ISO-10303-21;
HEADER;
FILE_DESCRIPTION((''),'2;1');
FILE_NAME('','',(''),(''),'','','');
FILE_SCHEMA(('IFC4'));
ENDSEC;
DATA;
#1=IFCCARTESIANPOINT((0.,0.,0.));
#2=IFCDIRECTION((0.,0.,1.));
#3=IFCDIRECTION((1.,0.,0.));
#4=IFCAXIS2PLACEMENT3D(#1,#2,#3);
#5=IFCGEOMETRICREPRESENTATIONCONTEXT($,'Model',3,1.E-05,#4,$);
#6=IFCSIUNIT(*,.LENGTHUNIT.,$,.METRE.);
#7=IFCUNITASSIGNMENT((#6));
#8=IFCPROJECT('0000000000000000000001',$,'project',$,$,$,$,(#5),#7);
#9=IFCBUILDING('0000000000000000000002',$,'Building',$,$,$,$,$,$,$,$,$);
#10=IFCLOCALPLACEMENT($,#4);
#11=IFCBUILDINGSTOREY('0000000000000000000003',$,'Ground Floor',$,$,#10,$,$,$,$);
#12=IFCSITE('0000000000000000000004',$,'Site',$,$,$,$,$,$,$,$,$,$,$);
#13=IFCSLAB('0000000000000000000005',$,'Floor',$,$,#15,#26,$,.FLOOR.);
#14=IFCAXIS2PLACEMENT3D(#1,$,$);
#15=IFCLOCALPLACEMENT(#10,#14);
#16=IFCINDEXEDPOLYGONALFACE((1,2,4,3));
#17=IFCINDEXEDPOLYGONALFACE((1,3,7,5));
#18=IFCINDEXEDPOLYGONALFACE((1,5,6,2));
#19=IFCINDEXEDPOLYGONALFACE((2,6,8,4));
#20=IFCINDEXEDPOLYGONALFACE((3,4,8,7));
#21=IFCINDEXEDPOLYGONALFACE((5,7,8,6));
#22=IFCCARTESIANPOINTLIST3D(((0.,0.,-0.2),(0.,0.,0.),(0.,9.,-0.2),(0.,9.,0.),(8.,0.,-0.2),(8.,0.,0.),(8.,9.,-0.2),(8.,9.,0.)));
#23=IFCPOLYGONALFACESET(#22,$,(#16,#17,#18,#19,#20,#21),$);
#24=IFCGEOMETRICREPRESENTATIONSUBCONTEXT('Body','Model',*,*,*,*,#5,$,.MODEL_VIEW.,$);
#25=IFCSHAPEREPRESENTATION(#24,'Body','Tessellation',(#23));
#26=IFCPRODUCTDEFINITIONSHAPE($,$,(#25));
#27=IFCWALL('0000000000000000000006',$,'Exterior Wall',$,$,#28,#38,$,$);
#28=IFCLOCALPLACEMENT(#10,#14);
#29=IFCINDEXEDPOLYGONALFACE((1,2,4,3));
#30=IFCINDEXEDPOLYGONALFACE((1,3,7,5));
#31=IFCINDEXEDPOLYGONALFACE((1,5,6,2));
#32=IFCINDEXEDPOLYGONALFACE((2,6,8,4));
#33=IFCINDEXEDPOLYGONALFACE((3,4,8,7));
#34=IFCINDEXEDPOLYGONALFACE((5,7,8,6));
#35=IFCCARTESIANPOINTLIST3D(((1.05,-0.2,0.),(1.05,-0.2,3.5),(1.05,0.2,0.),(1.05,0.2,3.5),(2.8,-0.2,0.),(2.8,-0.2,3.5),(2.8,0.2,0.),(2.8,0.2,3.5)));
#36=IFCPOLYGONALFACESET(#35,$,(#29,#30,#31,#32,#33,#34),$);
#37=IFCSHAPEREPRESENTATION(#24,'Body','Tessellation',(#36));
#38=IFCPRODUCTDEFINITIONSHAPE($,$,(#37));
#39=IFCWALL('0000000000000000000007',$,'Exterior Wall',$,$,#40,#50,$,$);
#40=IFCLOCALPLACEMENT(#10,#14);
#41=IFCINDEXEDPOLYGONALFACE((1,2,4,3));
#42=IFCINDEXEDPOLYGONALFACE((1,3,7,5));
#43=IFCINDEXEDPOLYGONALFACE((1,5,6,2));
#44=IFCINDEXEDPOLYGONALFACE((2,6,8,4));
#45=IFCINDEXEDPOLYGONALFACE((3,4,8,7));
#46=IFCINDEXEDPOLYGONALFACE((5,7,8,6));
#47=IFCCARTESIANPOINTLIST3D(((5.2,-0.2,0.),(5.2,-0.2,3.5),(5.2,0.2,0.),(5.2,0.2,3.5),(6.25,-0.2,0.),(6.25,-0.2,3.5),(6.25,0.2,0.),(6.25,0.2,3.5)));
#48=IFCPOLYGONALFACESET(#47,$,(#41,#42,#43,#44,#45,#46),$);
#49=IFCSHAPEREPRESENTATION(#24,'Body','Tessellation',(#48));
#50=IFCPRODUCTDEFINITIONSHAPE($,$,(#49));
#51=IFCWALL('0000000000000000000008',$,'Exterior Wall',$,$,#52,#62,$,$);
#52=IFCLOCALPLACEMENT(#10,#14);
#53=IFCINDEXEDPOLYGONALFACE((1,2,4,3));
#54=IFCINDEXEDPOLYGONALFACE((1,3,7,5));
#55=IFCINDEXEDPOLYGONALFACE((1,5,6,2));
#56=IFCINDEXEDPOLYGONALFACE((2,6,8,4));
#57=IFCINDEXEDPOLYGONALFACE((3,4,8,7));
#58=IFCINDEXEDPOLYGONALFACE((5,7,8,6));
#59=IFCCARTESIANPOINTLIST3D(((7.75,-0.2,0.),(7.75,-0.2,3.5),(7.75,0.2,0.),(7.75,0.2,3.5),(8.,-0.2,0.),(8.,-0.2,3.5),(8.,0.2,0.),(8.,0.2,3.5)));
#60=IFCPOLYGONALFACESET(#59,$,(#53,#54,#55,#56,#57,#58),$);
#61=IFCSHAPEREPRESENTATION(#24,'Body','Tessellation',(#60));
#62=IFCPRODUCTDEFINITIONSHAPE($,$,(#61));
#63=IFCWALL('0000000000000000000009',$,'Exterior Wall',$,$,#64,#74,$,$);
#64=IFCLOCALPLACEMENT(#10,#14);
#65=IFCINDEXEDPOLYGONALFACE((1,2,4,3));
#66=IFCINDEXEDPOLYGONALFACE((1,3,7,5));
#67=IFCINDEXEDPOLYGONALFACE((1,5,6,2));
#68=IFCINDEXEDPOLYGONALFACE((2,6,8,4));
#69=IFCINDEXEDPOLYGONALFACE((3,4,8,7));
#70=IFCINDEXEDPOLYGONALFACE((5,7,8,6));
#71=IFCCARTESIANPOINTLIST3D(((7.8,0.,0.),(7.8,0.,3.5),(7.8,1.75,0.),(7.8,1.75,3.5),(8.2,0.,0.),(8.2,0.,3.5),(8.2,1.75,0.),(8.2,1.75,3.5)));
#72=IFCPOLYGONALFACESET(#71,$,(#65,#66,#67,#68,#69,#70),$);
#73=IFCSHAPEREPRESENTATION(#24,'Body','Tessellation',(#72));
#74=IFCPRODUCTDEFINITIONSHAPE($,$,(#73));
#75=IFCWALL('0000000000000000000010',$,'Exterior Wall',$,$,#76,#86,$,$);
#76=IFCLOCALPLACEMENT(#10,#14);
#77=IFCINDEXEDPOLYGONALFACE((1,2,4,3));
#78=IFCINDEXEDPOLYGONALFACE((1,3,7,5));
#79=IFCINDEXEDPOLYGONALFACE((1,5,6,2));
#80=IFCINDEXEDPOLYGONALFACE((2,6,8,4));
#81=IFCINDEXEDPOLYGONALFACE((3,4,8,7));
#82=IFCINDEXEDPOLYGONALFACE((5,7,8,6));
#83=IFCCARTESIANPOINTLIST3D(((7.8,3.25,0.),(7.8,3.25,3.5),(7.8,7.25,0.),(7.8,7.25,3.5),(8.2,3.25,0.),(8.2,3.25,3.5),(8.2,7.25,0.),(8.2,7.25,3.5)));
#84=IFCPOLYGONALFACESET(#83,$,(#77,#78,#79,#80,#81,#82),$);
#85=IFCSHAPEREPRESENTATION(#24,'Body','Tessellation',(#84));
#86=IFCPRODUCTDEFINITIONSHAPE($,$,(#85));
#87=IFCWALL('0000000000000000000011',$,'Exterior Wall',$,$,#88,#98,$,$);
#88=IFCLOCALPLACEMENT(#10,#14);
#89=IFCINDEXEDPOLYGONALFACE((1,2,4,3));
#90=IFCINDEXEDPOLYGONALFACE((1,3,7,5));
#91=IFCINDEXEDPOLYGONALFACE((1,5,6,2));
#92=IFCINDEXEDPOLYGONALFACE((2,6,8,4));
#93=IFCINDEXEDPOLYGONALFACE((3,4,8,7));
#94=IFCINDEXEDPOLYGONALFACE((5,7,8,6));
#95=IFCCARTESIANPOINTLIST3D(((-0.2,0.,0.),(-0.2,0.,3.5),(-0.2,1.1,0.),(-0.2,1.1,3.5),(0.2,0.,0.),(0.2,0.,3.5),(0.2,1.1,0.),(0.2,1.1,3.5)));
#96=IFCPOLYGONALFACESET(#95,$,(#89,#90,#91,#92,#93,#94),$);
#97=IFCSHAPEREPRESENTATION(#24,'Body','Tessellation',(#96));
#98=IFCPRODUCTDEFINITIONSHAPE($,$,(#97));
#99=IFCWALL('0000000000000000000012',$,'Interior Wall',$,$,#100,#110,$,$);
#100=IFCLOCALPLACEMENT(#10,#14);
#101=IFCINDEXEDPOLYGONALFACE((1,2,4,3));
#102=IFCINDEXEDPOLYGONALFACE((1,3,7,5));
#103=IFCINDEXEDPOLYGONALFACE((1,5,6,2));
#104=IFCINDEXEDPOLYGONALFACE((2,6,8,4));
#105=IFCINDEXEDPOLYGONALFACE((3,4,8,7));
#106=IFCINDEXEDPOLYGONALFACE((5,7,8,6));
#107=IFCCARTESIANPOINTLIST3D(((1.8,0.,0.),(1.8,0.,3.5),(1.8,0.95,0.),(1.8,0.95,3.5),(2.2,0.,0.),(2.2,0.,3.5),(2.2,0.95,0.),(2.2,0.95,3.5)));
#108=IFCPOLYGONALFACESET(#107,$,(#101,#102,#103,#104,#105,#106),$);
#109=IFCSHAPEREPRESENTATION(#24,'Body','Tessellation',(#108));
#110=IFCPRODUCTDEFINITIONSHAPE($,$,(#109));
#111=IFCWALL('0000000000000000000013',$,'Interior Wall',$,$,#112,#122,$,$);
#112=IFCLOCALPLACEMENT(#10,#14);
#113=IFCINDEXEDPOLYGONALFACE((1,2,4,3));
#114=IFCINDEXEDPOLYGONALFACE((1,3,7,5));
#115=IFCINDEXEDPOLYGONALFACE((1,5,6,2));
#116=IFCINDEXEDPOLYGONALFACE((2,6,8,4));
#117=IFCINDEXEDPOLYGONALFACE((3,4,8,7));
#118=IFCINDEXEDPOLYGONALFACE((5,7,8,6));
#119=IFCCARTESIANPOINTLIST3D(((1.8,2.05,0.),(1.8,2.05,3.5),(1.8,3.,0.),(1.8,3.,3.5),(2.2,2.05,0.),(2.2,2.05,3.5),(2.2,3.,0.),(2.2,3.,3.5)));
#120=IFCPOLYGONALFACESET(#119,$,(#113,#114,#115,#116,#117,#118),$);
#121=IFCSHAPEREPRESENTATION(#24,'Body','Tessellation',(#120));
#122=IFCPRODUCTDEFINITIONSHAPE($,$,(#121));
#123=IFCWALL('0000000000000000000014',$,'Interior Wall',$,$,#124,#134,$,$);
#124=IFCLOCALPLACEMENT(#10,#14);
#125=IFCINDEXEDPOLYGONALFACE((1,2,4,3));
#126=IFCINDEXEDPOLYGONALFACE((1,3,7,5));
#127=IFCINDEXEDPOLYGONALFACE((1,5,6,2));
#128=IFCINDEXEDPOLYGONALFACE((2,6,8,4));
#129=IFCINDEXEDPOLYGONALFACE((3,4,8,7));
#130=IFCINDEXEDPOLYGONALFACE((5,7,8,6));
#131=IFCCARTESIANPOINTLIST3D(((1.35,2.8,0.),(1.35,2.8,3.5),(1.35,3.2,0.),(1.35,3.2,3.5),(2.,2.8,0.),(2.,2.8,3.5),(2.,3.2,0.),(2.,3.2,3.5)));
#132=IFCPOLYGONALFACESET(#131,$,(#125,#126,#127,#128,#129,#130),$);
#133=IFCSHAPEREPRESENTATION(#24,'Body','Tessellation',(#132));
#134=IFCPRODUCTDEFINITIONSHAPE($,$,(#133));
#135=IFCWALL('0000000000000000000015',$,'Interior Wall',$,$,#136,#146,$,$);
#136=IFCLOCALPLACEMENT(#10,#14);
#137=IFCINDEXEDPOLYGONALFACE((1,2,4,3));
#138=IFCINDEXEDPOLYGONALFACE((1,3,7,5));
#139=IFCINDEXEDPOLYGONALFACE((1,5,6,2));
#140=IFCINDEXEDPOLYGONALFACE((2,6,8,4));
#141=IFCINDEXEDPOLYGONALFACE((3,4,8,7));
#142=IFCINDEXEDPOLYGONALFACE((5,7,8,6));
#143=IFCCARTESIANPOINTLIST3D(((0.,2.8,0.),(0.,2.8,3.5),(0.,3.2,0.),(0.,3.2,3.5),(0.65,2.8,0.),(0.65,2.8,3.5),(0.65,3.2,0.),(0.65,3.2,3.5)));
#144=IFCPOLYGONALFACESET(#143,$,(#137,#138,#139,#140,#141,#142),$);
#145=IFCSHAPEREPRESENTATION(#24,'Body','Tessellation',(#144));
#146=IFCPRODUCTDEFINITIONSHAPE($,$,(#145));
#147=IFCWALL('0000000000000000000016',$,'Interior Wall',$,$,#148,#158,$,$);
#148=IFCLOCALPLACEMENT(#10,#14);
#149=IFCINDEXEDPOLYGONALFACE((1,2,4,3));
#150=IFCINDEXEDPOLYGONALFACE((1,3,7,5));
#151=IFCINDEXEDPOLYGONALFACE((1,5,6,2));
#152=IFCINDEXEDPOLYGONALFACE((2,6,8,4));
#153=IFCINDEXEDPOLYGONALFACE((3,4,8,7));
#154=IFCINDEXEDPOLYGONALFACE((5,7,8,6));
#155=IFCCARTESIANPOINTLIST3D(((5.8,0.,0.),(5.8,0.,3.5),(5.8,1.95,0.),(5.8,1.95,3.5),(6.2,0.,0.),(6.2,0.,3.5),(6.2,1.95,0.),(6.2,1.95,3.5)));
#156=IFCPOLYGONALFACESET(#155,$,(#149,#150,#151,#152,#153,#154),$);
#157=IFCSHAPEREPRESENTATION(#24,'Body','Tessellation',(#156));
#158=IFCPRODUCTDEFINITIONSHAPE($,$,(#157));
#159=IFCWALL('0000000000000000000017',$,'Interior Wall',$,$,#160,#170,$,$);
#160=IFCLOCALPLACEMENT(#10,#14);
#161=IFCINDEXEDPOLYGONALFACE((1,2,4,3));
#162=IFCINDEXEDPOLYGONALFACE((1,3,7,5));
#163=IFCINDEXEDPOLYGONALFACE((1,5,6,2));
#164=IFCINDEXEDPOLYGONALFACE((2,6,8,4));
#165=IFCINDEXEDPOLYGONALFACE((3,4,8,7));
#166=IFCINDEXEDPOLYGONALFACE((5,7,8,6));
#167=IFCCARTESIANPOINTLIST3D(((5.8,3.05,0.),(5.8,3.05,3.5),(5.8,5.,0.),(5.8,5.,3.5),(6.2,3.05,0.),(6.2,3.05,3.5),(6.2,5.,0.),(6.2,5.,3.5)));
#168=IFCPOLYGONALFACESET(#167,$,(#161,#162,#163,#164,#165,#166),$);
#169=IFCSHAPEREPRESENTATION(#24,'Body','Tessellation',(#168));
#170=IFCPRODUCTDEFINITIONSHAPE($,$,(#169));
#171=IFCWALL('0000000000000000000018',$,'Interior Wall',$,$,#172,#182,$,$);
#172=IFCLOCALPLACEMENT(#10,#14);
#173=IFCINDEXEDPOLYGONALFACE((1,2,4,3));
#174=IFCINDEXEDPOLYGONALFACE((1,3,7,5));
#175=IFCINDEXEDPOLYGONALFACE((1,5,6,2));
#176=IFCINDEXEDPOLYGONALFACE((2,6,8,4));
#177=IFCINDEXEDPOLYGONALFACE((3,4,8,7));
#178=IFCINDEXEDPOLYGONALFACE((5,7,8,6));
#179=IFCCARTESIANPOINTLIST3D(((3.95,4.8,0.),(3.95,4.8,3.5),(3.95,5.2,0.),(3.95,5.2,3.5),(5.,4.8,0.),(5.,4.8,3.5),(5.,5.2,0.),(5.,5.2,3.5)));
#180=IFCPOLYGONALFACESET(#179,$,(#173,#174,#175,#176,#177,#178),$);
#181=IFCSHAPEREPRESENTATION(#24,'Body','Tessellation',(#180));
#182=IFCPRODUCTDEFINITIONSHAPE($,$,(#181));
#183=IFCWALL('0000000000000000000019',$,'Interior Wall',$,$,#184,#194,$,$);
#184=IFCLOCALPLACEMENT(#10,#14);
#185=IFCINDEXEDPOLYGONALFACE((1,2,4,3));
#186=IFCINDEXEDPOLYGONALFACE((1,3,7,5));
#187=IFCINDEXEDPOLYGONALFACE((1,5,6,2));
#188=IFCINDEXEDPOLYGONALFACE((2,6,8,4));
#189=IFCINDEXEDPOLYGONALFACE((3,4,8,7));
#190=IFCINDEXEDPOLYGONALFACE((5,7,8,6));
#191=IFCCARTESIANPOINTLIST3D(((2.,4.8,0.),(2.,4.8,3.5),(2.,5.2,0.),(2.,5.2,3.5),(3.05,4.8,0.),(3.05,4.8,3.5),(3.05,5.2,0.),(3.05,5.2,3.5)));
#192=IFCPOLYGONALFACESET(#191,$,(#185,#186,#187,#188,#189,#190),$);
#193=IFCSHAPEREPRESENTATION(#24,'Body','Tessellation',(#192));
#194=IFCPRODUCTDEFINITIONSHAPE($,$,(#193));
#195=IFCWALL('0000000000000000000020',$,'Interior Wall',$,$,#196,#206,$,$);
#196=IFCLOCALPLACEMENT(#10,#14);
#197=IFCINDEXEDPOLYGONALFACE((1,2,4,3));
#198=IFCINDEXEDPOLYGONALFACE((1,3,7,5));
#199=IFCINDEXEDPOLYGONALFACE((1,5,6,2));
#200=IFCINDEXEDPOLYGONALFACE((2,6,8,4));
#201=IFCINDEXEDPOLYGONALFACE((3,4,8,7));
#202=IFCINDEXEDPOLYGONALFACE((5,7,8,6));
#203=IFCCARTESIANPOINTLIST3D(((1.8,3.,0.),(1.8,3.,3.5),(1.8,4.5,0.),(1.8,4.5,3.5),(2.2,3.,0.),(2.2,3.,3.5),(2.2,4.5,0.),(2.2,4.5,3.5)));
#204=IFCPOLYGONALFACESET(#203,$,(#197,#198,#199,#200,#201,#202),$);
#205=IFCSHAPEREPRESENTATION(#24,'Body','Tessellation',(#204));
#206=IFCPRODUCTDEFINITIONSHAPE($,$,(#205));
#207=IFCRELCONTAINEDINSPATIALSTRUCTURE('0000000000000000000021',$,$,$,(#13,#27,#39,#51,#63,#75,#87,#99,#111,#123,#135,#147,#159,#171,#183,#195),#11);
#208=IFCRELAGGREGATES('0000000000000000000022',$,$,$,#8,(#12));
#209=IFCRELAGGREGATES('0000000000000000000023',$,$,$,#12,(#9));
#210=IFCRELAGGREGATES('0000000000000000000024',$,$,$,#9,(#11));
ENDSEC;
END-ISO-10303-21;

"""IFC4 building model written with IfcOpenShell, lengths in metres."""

from ifc_helpers import new_model, si_unit, frame, origin_with_axes, place, context, subcontext, project, spatial, indexed_curve, outline, extrude, element, save


model = new_model("IFC4")

# Units and contexts
model_context = context("Model", 3, precision=1e-05, world=origin_with_axes())
body_context = subcontext(model_context, "Body", "Model", "MODEL_VIEW")
ifc_project = project(units=[si_unit("LENGTHUNIT", "METRE")], contexts=[model_context])

# Site, building, storey
site = spatial("IfcSite", under=ifc_project, Name="Site")
building = spatial("IfcBuilding", under=site, Name="Building")
storey_placement = place(None, origin_with_axes())
storey = spatial("IfcBuildingStorey", under=building, at=storey_placement, Name="Ground Floor")

# Slab
slab_placement = place(storey_placement, frame((0.0, 0.0, -0.2), z_axis=(0.0, 0.0, 1.0), x_axis=(1.0, 0.0, 0.0)))
element("IfcSlab", 1, at=slab_placement, inside=storey, Name="Floor", PredefinedType="FLOOR", context=body_context, shape_type="SweptSolid", body=[
    extrude(outline(indexed_curve([(0.0, 0.0), (8.0, 0.0), (8.0, 9.0), (0.0, 9.0)])), None, (0.0, 0.0, 1.0), 0.2),
])

# Walls
wall_1_placement = place(storey_placement, frame((1.05, 0.0, 0.0), z_axis=(0.0, 0.0, 1.0), x_axis=(1.0, 0.0, 0.0)))
element("IfcWall", 2, at=wall_1_placement, inside=storey, Name="Exterior Wall", context=body_context, shape_type="SweptSolid", body=[
    extrude(outline(indexed_curve([(0.0, 0.0), (0.0, 0.4), (1.75, 0.4), (1.75, 0.0), (0.0, 0.0)], self_intersect=False)), frame((0.0, -0.2, 0.0), z_axis=(0.0, 0.0, 1.0), x_axis=(1.0, 0.0, 0.0)), (0.0, 0.0, 1.0), 3.5),
])
wall_2_placement = place(storey_placement, frame((5.2, 0.0, 0.0), z_axis=(0.0, 0.0, 1.0), x_axis=(1.0, 0.0, 0.0)))
element("IfcWall", 3, at=wall_2_placement, inside=storey, Name="Exterior Wall", context=body_context, shape_type="SweptSolid", body=[
    extrude(outline(indexed_curve([(0.0, 0.0), (0.0, 0.4), (1.05, 0.4), (1.05, 0.0), (0.0, 0.0)], self_intersect=False)), frame((0.0, -0.2, 0.0), z_axis=(0.0, 0.0, 1.0), x_axis=(1.0, 0.0, 0.0)), (0.0, 0.0, 1.0), 3.5),
])
wall_3_placement = place(storey_placement, frame((7.75, 0.0, 0.0), z_axis=(0.0, 0.0, 1.0), x_axis=(1.0, 0.0, 0.0)))
element("IfcWall", 4, at=wall_3_placement, inside=storey, Name="Exterior Wall", context=body_context, shape_type="SweptSolid", body=[
    extrude(outline(indexed_curve([(0.0, 0.0), (0.0, 0.4), (0.25, 0.4), (0.25, 0.0), (0.0, 0.0)], self_intersect=False)), frame((0.0, -0.2, 0.0), z_axis=(0.0, 0.0, 1.0), x_axis=(1.0, 0.0, 0.0)), (0.0, 0.0, 1.0), 3.5),
])
wall_4_placement = place(storey_placement, frame((8.0, 0.0, 0.0), z_axis=(0.0, 0.0, 1.0), x_axis=(0.0, 1.0, 0.0)))
element("IfcWall", 5, at=wall_4_placement, inside=storey, Name="Exterior Wall", context=body_context, shape_type="SweptSolid", body=[
    extrude(outline(indexed_curve([(0.0, 0.0), (0.0, 0.4), (1.75, 0.4), (1.75, 0.0), (0.0, 0.0)], self_intersect=False)), frame((0.0, -0.2, 0.0), z_axis=(0.0, 0.0, 1.0), x_axis=(1.0, 0.0, 0.0)), (0.0, 0.0, 1.0), 3.5),
])
wall_5_placement = place(storey_placement, frame((8.0, 3.25, 0.0), z_axis=(0.0, 0.0, 1.0), x_axis=(0.0, 1.0, 0.0)))
element("IfcWall", 6, at=wall_5_placement, inside=storey, Name="Exterior Wall", context=body_context, shape_type="SweptSolid", body=[
    extrude(outline(indexed_curve([(0.0, 0.0), (0.0, 0.4), (4.0, 0.4), (4.0, 0.0), (0.0, 0.0)], self_intersect=False)), frame((0.0, -0.2, 0.0), z_axis=(0.0, 0.0, 1.0), x_axis=(1.0, 0.0, 0.0)), (0.0, 0.0, 1.0), 3.5),
])
wall_6_placement = place(storey_placement, frame((0.0, 1.1, 0.0), z_axis=(0.0, 0.0, 1.0), x_axis=(0.0, -1.0, 0.0)))
element("IfcWall", 7, at=wall_6_placement, inside=storey, Name="Exterior Wall", context=body_context, shape_type="SweptSolid", body=[
    extrude(outline(indexed_curve([(0.0, 0.0), (0.0, 0.4), (1.1, 0.4), (1.1, 0.0), (0.0, 0.0)], self_intersect=False)), frame((0.0, -0.2, 0.0), z_axis=(0.0, 0.0, 1.0), x_axis=(1.0, 0.0, 0.0)), (0.0, 0.0, 1.0), 3.5),
])
wall_7_placement = place(storey_placement, frame((2.0, 0.0, 0.0), z_axis=(0.0, 0.0, 1.0), x_axis=(0.0, 1.0, 0.0)))
element("IfcWall", 8, at=wall_7_placement, inside=storey, Name="Interior Wall", context=body_context, shape_type="SweptSolid", body=[
    extrude(outline(indexed_curve([(0.0, 0.0), (0.0, 0.4), (0.95, 0.4), (0.95, 0.0), (0.0, 0.0)], self_intersect=False)), frame((0.0, -0.2, 0.0), z_axis=(0.0, 0.0, 1.0), x_axis=(1.0, 0.0, 0.0)), (0.0, 0.0, 1.0), 3.5),
])
wall_8_placement = place(storey_placement, frame((2.0, 2.05, 0.0), z_axis=(0.0, 0.0, 1.0), x_axis=(0.0, 1.0, 0.0)))
element("IfcWall", 9, at=wall_8_placement, inside=storey, Name="Interior Wall", context=body_context, shape_type="SweptSolid", body=[
    extrude(outline(indexed_curve([(0.0, 0.0), (0.0, 0.4), (0.95, 0.4), (0.95, 0.0), (0.0, 0.0)], self_intersect=False)), frame((0.0, -0.2, 0.0), z_axis=(0.0, 0.0, 1.0), x_axis=(1.0, 0.0, 0.0)), (0.0, 0.0, 1.0), 3.5),
])
for number, where, z_axis, x_axis, name in (
    (10, (2.0, 3.0, 0.0), (0.0, 0.0, 1.0), (-1.0, 0.0, 0.0), "Interior Wall"),
    (11, (0.65, 3.0, 0.0), (0.0, 0.0, 1.0), (-1.0, 0.0, 0.0), "Interior Wall"),
):
    element("IfcWall", number, at=place(storey_placement, frame(where, z_axis=z_axis, x_axis=x_axis)), inside=storey, Name=name, context=body_context, shape_type="SweptSolid", body=[
        extrude(outline(indexed_curve([(0.0, 0.0), (0.0, 0.4), (0.65, 0.4), (0.65, 0.0), (0.0, 0.0)], self_intersect=False)), frame((0.0, -0.2, 0.0), z_axis=(0.0, 0.0, 1.0), x_axis=(1.0, 0.0, 0.0)), (0.0, 0.0, 1.0), 3.5),
    ])
wall_9_placement = place(storey_placement, frame((6.0, 0.0, 0.0), z_axis=(0.0, 0.0, 1.0), x_axis=(0.0, 1.0, 0.0)))
element("IfcWall", 12, at=wall_9_placement, inside=storey, Name="Interior Wall", context=body_context, shape_type="SweptSolid", body=[
    extrude(outline(indexed_curve([(0.0, 0.0), (0.0, 0.4), (1.95, 0.4), (1.95, 0.0), (0.0, 0.0)], self_intersect=False)), frame((0.0, -0.2, 0.0), z_axis=(0.0, 0.0, 1.0), x_axis=(1.0, 0.0, 0.0)), (0.0, 0.0, 1.0), 3.5),
])
wall_10_placement = place(storey_placement, frame((6.0, 3.05, 0.0), z_axis=(0.0, 0.0, 1.0), x_axis=(0.0, 1.0, 0.0)))
element("IfcWall", 13, at=wall_10_placement, inside=storey, Name="Interior Wall", context=body_context, shape_type="SweptSolid", body=[
    extrude(outline(indexed_curve([(0.0, 0.0), (0.0, 0.4), (1.95, 0.4), (1.95, 0.0), (0.0, 0.0)], self_intersect=False)), frame((0.0, -0.2, 0.0), z_axis=(0.0, 0.0, 1.0), x_axis=(1.0, 0.0, 0.0)), (0.0, 0.0, 1.0), 3.5),
])
for number, where, z_axis, x_axis, name in (
    (14, (5.0, 5.0, 0.0), (0.0, 0.0, 1.0), (-1.0, 0.0, 0.0), "Interior Wall"),
    (15, (3.05, 5.0, 0.0), (0.0, 0.0, 1.0), (-1.0, 0.0, 0.0), "Interior Wall"),
):
    element("IfcWall", number, at=place(storey_placement, frame(where, z_axis=z_axis, x_axis=x_axis)), inside=storey, Name=name, context=body_context, shape_type="SweptSolid", body=[
        extrude(outline(indexed_curve([(0.0, 0.0), (0.0, 0.4), (1.05, 0.4), (1.05, 0.0), (0.0, 0.0)], self_intersect=False)), frame((0.0, -0.2, 0.0), z_axis=(0.0, 0.0, 1.0), x_axis=(1.0, 0.0, 0.0)), (0.0, 0.0, 1.0), 3.5),
    ])
wall_11_placement = place(storey_placement, frame((2.0, 4.5, 0.0), z_axis=(0.0, 0.0, 1.0), x_axis=(0.0, -1.0, 0.0)))
element("IfcWall", 16, at=wall_11_placement, inside=storey, Name="Interior Wall", context=body_context, shape_type="SweptSolid", body=[
    extrude(outline(indexed_curve([(0.0, 0.0), (0.0, 0.4), (1.5, 0.4), (1.5, 0.0), (0.0, 0.0)], self_intersect=False)), frame((0.0, -0.2, 0.0), z_axis=(0.0, 0.0, 1.0), x_axis=(1.0, 0.0, 0.0)), (0.0, 0.0, 1.0), 3.5),
])

save(model, "model.ifc")
